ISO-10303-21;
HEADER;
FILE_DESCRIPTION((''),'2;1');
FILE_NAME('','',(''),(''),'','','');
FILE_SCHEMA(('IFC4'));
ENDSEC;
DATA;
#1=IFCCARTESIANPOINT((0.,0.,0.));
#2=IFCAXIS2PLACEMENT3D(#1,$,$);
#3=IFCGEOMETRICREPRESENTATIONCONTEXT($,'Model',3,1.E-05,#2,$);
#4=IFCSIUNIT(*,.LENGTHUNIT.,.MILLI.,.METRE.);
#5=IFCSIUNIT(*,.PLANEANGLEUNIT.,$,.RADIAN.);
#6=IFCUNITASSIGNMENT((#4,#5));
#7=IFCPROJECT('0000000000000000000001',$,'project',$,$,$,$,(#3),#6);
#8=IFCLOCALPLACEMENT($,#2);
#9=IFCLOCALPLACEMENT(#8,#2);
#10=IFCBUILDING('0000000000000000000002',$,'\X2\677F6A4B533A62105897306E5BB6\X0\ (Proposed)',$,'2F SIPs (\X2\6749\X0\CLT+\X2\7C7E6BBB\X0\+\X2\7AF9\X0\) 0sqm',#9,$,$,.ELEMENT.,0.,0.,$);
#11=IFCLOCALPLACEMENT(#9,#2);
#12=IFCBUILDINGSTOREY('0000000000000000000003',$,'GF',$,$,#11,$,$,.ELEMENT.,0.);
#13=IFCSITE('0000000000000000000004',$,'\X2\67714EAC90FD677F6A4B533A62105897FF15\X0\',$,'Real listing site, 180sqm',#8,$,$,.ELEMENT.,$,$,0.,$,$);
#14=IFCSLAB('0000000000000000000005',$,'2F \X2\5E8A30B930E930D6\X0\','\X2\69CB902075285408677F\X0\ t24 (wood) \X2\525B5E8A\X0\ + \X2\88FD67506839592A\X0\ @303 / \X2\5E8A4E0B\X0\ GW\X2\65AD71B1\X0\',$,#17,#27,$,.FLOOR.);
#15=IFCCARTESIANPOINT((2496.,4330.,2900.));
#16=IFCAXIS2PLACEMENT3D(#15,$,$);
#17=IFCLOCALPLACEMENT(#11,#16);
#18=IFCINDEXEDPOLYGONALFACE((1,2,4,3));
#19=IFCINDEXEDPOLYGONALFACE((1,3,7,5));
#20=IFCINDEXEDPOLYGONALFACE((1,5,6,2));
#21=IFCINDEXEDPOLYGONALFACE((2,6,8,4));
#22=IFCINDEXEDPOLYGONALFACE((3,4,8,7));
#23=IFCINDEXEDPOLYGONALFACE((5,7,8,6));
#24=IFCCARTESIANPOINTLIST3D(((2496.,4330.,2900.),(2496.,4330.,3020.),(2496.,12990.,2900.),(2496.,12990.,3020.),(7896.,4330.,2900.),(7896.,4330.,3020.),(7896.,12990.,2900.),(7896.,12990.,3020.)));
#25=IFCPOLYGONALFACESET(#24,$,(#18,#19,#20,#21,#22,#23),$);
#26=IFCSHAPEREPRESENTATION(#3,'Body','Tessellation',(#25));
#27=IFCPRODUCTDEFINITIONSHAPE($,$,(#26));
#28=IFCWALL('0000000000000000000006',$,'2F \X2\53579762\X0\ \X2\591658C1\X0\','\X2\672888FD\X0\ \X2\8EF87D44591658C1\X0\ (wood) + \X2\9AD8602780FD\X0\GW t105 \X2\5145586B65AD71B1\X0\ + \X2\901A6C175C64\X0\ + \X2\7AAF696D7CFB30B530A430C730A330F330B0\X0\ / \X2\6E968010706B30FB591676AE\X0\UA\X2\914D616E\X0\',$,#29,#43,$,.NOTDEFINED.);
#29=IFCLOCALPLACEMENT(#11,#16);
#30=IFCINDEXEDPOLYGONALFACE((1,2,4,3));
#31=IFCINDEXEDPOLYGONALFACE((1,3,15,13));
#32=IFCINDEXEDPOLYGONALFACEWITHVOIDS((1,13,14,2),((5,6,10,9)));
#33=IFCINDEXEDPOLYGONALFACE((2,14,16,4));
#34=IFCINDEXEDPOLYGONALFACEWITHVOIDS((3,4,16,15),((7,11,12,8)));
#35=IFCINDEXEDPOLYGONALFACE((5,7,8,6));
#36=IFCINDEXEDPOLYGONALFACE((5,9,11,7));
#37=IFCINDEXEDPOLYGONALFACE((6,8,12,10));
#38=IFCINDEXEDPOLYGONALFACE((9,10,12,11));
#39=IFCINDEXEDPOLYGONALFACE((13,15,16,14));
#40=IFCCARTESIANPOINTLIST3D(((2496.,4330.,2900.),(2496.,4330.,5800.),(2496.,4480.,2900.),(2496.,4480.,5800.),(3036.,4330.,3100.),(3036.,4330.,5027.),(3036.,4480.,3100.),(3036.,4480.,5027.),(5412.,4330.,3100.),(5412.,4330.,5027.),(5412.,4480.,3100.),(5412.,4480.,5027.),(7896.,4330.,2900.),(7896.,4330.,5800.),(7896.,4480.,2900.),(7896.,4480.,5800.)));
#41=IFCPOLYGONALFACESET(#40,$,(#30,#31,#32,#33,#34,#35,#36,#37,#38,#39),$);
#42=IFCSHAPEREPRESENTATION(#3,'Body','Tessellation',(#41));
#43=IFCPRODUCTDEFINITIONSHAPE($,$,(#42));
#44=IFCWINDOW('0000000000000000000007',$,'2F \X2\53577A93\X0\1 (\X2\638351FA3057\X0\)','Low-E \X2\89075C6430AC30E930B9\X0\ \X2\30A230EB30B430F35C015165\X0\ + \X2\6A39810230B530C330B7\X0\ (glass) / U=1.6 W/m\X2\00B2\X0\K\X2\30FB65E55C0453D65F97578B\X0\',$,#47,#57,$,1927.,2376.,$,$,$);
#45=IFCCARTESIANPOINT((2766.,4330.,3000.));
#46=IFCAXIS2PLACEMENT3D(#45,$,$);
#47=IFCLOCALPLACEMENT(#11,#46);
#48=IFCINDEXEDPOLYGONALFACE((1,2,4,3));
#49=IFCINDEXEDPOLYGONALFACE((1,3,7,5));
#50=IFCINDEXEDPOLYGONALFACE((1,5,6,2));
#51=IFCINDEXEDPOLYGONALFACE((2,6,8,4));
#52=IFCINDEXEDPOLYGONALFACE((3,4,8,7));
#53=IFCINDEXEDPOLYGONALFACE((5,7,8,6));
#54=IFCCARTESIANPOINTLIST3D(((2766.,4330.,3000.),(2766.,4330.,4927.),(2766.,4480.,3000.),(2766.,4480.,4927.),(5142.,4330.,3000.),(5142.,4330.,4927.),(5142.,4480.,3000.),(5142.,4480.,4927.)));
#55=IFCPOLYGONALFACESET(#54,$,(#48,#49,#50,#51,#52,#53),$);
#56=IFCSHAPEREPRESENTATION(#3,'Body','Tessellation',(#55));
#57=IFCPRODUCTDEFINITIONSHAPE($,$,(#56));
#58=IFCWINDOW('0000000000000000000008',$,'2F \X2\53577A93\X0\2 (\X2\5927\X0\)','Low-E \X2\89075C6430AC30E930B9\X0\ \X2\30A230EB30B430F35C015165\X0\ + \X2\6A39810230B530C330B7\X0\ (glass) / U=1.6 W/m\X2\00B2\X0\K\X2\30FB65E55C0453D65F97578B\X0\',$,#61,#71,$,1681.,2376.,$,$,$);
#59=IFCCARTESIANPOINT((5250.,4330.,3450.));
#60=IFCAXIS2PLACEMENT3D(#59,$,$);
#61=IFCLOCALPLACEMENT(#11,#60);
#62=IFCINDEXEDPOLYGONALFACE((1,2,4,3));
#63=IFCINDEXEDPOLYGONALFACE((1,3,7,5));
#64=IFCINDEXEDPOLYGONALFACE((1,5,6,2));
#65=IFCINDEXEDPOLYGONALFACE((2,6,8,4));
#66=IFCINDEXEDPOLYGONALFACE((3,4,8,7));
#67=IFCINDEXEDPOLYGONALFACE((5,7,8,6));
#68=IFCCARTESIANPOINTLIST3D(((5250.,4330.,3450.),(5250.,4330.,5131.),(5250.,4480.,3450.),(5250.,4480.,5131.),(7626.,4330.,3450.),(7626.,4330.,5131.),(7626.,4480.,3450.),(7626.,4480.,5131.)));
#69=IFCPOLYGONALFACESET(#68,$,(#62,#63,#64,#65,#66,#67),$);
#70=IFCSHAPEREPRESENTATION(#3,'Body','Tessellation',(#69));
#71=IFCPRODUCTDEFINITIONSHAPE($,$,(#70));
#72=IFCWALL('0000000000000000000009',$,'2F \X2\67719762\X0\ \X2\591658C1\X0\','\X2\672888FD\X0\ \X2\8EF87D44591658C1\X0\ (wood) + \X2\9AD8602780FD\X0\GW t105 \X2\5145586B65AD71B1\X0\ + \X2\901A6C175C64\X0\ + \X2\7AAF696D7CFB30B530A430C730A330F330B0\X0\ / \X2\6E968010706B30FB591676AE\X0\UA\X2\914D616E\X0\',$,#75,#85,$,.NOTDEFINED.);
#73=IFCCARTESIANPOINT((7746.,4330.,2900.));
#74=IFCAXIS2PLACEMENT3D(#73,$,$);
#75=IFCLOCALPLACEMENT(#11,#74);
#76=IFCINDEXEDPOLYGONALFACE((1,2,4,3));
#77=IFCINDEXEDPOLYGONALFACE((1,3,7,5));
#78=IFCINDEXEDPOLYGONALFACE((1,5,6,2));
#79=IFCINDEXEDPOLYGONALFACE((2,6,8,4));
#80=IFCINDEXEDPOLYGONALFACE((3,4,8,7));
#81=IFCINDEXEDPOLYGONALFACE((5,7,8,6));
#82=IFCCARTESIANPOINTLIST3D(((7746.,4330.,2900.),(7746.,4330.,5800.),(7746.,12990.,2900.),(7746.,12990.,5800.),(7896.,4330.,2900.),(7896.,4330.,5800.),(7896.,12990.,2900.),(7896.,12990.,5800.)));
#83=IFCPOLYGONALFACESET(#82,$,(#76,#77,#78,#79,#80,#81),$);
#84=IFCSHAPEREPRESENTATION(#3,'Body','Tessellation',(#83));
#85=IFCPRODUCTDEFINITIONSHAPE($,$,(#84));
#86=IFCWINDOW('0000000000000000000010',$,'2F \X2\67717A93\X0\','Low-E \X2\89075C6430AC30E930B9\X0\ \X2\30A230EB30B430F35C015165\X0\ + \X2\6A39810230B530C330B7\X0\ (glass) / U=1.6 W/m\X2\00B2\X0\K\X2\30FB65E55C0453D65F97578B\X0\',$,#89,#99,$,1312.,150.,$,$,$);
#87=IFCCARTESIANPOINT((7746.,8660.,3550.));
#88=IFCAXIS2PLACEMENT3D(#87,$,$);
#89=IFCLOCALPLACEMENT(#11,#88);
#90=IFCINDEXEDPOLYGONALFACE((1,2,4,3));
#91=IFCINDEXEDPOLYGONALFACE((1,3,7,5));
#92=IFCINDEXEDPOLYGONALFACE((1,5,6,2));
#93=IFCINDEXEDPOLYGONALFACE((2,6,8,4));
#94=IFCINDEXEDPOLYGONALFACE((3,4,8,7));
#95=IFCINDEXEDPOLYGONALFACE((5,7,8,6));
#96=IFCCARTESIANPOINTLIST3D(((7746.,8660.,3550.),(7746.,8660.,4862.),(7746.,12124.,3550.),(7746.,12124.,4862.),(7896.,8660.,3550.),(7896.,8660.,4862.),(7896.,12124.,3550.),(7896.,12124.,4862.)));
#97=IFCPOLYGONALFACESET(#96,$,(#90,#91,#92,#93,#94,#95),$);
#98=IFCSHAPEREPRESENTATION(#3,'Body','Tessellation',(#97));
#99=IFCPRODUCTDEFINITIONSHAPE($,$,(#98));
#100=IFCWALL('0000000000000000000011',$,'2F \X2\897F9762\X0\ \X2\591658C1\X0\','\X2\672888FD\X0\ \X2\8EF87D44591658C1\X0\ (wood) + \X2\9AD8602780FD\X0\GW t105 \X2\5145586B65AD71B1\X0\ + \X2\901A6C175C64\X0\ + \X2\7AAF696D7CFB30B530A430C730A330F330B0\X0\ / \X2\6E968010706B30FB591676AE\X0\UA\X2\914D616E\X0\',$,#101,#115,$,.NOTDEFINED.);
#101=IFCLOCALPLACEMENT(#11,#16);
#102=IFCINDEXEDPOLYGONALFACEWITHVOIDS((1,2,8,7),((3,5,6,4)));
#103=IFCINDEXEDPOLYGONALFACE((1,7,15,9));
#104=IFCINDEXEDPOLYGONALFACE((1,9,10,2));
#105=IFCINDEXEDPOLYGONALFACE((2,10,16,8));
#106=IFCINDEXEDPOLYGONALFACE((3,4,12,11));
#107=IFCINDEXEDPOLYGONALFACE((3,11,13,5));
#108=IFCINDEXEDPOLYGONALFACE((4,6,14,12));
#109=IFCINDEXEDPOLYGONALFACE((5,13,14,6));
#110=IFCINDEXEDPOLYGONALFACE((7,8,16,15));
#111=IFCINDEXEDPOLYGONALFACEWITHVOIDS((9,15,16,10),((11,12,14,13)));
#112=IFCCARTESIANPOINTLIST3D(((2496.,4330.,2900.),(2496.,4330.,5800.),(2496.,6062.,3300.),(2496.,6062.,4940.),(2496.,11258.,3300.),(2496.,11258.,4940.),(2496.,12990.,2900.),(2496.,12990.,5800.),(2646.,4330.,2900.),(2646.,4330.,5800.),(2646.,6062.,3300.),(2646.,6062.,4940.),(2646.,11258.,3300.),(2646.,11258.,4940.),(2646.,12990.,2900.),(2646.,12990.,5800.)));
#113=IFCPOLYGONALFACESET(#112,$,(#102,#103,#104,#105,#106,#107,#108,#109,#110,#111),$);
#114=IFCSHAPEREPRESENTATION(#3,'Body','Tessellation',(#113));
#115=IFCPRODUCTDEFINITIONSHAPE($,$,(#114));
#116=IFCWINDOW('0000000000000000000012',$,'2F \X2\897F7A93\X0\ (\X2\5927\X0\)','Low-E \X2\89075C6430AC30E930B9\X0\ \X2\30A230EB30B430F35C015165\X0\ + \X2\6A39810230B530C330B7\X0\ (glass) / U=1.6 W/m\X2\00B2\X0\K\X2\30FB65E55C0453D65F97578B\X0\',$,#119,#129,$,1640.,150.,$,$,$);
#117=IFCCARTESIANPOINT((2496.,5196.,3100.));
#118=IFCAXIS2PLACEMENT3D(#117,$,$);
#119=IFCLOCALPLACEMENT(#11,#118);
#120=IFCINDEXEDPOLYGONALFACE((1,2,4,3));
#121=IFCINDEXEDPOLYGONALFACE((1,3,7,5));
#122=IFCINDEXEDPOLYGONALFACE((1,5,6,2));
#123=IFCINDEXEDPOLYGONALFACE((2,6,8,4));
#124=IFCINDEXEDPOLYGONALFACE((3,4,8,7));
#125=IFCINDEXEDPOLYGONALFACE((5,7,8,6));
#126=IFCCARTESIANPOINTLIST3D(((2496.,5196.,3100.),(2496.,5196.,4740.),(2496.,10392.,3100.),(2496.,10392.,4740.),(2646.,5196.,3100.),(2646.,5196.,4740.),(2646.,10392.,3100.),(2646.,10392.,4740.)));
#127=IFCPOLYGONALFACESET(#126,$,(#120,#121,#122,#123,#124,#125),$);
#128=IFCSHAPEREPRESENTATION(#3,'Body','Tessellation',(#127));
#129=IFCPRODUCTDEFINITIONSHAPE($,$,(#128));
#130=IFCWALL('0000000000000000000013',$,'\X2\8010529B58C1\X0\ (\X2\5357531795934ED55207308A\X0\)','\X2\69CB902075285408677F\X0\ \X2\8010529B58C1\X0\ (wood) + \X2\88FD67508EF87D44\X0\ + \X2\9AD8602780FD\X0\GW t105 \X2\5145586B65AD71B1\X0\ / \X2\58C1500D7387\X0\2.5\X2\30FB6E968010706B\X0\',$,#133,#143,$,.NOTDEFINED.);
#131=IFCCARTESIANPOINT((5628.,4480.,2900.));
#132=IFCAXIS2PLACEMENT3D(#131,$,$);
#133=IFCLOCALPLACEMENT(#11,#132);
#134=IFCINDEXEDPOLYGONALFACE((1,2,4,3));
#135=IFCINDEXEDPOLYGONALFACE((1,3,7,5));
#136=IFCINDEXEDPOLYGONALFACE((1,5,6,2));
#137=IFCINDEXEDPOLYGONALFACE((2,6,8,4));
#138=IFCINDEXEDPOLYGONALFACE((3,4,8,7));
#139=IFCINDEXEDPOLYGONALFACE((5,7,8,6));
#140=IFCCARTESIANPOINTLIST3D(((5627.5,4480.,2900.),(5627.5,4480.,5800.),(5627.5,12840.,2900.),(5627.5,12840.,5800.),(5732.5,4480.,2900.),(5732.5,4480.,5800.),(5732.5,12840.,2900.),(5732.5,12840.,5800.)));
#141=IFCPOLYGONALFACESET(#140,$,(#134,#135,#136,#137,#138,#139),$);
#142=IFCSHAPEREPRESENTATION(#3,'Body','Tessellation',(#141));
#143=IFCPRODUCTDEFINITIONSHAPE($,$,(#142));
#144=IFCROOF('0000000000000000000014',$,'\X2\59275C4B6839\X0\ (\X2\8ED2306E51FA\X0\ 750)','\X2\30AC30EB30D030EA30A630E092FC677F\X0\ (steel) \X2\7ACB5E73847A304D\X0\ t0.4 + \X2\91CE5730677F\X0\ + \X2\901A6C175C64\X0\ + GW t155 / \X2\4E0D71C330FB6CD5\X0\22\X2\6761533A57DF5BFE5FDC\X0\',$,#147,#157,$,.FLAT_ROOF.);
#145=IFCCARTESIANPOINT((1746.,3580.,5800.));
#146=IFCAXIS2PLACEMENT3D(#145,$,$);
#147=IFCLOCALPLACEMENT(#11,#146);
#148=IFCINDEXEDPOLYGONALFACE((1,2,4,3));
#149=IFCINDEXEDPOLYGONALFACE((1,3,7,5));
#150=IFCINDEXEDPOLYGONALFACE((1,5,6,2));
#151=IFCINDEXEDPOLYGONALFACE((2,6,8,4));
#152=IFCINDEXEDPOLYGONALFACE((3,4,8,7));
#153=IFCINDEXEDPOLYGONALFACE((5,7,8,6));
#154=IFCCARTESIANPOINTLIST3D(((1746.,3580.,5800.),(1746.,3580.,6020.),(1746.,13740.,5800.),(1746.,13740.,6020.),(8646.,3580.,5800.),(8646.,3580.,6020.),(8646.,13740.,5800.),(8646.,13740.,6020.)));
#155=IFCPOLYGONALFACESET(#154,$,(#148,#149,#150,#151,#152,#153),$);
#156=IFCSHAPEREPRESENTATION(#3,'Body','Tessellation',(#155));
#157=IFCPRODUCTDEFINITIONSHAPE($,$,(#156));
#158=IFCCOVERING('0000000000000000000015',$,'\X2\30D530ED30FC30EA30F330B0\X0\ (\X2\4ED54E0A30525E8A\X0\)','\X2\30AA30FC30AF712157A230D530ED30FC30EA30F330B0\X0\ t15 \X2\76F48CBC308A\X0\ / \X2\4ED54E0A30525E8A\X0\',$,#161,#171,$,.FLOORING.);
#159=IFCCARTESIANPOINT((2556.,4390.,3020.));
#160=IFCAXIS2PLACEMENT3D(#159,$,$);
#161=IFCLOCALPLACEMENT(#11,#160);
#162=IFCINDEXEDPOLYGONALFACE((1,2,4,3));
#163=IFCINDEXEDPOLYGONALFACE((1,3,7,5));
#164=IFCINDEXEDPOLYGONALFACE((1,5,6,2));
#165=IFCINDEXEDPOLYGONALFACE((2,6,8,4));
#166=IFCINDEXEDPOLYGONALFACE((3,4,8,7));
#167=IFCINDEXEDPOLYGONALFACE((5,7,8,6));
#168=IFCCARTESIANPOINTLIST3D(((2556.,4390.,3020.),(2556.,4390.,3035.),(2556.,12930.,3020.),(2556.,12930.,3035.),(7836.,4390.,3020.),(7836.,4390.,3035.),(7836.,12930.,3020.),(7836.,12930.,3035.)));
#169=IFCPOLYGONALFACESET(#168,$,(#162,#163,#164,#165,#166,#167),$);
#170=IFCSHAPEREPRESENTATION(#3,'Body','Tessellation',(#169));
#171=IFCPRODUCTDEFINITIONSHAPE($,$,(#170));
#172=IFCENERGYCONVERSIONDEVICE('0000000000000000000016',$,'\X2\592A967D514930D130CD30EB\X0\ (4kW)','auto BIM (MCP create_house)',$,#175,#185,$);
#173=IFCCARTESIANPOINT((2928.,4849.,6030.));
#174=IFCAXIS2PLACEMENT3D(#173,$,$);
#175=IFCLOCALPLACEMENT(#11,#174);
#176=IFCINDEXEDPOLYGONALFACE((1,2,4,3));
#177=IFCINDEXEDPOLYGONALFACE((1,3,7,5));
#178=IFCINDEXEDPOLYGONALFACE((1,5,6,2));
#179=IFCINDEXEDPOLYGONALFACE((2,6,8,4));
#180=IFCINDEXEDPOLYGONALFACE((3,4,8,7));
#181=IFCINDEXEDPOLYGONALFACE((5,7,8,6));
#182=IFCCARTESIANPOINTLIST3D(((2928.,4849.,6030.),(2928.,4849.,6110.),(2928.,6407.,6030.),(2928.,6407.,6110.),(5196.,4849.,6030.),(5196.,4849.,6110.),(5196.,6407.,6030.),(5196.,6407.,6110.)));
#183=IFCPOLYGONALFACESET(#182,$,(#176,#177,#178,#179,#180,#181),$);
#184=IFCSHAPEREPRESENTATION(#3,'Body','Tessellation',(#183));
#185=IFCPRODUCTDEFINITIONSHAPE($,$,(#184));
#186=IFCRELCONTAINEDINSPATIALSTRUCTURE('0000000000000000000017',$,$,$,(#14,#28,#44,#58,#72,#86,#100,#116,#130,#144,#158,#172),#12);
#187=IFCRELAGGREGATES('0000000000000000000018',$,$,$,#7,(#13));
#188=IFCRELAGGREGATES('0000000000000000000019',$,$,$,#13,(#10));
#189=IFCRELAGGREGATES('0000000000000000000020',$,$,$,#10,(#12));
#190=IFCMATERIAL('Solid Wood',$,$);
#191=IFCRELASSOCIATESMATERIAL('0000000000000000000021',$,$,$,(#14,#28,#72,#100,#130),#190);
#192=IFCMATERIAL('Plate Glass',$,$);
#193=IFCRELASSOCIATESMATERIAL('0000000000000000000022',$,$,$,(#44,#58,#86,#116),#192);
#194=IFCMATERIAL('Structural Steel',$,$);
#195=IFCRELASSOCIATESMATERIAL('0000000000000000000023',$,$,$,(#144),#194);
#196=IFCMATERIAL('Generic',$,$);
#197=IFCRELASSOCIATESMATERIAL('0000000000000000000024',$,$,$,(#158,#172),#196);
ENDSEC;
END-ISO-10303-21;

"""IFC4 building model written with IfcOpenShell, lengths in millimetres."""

from ifc_helpers import new_model, si_unit, frame, frame_2d, origin, place, context, project, spatial, rectangle, extrude, material, element, fill, save


model = new_model("IFC4")

# Units and contexts
model_context = context("Model", 3, precision=1e-05, world=origin())
ifc_project = project(units=[si_unit("LENGTHUNIT", "METRE", prefix="MILLI"), si_unit("PLANEANGLEUNIT", "RADIAN")], contexts=[model_context])

# Site, building, storey
site_placement = place(None, origin())
site = spatial("IfcSite", under=ifc_project, at=site_placement, Name="東京都板橋区成増５", ObjectType="Real listing site, 180sqm", CompositionType="ELEMENT", RefElevation=0.0)
building_placement = place(site_placement, origin())
building = spatial("IfcBuilding", under=site, at=building_placement, Name="板橋区成増の家 (Proposed)", ObjectType="2F SIPs (杉CLT+籾殻+竹) 0sqm", CompositionType="ELEMENT", ElevationOfRefHeight=0.0, ElevationOfTerrain=0.0)
storey_placement = place(building_placement, origin())
storey = spatial("IfcBuildingStorey", under=building, at=storey_placement, Name="GF", CompositionType="ELEMENT", Elevation=0.0)

# Slab
ifc_material_1 = material(Name="Solid Wood")
slab_placement = place(storey_placement, frame((2496.0, 4330.0, 2900.0)))
element("IfcSlab", 1, at=slab_placement, inside=storey, material=ifc_material_1, Name="2F 床スラブ", Description="構造用合板 t24 (wood) 剛床 + 製材根太 @303 / 床下 GW断熱", PredefinedType="FLOOR", context=model_context, shape_type="SweptSolid", body=[
    extrude(rectangle(XDim=5400.0, YDim=8660.0, at=frame_2d((2700.0, 4330.0))), frame((2496.0, 4330.0, 2900.0)), (0.0, 0.0, 1.0), 120.0),
])

# Wall, openings, windows
wall_1_placement = place(storey_placement, frame((2496.0, 4330.0, 2900.0)))
wall_1 = element("IfcWall", 2, at=wall_1_placement, inside=storey, material=ifc_material_1, Name="2F 南面 外壁", Description="木製 軸組外壁 (wood) + 高性能GW t105 充填断熱 + 通気層 + 窯業系サイディング / 準耐火・外皮UA配慮", PredefinedType="NOTDEFINED", context=model_context, shape_type="SweptSolid", body=[
    extrude(rectangle(XDim=5400.0, YDim=150.0, at=frame_2d((2700.0, 75.0))), frame((2496.0, 4330.0, 2900.0)), (0.0, 0.0, 1.0), 2900.0),
])
opening_1_placement = place(storey_placement, frame((2766.0, 4330.0, 3000.0)))
opening_1 = element("IfcOpeningElement", 3, at=opening_1_placement, cuts=wall_1, PredefinedType="NOTDEFINED", context=model_context, shape_type="SweptSolid", body=[
    extrude(rectangle(XDim=2376.0, YDim=150.0, at=frame_2d((1188.0, 75.0))), frame((2766.0, 4330.0, 3000.0)), (0.0, 0.0, 1.0), 1927.0),
])
opening_2_placement = place(storey_placement, frame((5250.0, 4330.0, 3450.0)))
opening_2 = element("IfcOpeningElement", 4, at=opening_2_placement, cuts=wall_1, PredefinedType="NOTDEFINED", context=model_context, shape_type="SweptSolid", body=[
    extrude(rectangle(XDim=2376.0, YDim=150.0, at=frame_2d((1188.0, 75.0))), frame((5250.0, 4330.0, 3450.0)), (0.0, 0.0, 1.0), 1681.0),
])
ifc_material_2 = material(Name="Plate Glass")
window_1_placement = place(storey_placement, frame((2766.0, 4330.0, 3000.0)))
window_1 = element("IfcWindow", 5, at=window_1_placement, inside=storey, material=ifc_material_2, Name="2F 南窓1 (掃出し)", Description="Low-E 複層ガラス アルゴン封入 + 樹脂サッシ (glass) / U=1.6 W/m²K・日射取得型", OverallHeight=1927.0, OverallWidth=2376.0, context=model_context, shape_type="SweptSolid", body=[
    extrude(rectangle(XDim=2376.0, YDim=150.0, at=frame_2d((1188.0, 75.0))), frame((2766.0, 4330.0, 3000.0)), (0.0, 0.0, 1.0), 1927.0),
])
fill(opening_1, window_1)
window_2_placement = place(storey_placement, frame((5250.0, 4330.0, 3450.0)))
window_2 = element("IfcWindow", 6, at=window_2_placement, inside=storey, material=ifc_material_2, Name="2F 南窓2 (大)", Description="Low-E 複層ガラス アルゴン封入 + 樹脂サッシ (glass) / U=1.6 W/m²K・日射取得型", OverallHeight=1681.0, OverallWidth=2376.0, context=model_context, shape_type="SweptSolid", body=[
    extrude(rectangle(XDim=2376.0, YDim=150.0, at=frame_2d((1188.0, 75.0))), frame((5250.0, 4330.0, 3450.0)), (0.0, 0.0, 1.0), 1681.0),
])
fill(opening_2, window_2)

# Walls, openings, windows
wall_2_placement = place(storey_placement, frame((7746.0, 4330.0, 2900.0)))
wall_2 = element("IfcWall", 7, at=wall_2_placement, inside=storey, material=ifc_material_1, Name="2F 東面 外壁", Description="木製 軸組外壁 (wood) + 高性能GW t105 充填断熱 + 通気層 + 窯業系サイディング / 準耐火・外皮UA配慮", PredefinedType="NOTDEFINED", context=model_context, shape_type="SweptSolid", body=[
    extrude(rectangle(XDim=150.0, YDim=8660.0, at=frame_2d((75.0, 4330.0))), frame((7746.0, 4330.0, 2900.0)), (0.0, 0.0, 1.0), 2900.0),
])
opening_3_placement = place(storey_placement, frame((7746.0, 8660.0, 3550.0)))
opening_3 = element("IfcOpeningElement", 8, at=opening_3_placement, cuts=wall_2, PredefinedType="NOTDEFINED", context=model_context, shape_type="SweptSolid", body=[
    extrude(rectangle(XDim=150.0, YDim=3464.0, at=frame_2d((75.0, 1732.0))), frame((7746.0, 8660.0, 3550.0)), (0.0, 0.0, 1.0), 1312.0),
])
window_3_placement = place(storey_placement, frame((7746.0, 8660.0, 3550.0)))
window_3 = element("IfcWindow", 9, at=window_3_placement, inside=storey, material=ifc_material_2, Name="2F 東窓", Description="Low-E 複層ガラス アルゴン封入 + 樹脂サッシ (glass) / U=1.6 W/m²K・日射取得型", OverallHeight=1312.0, OverallWidth=150.0, context=model_context, shape_type="SweptSolid", body=[
    extrude(rectangle(XDim=150.0, YDim=3464.0, at=frame_2d((75.0, 1732.0))), frame((7746.0, 8660.0, 3550.0)), (0.0, 0.0, 1.0), 1312.0),
])
fill(opening_3, window_3)
wall_3_placement = place(storey_placement, frame((2496.0, 4330.0, 2900.0)))
wall_3 = element("IfcWall", 10, at=wall_3_placement, inside=storey, material=ifc_material_1, Name="2F 西面 外壁", Description="木製 軸組外壁 (wood) + 高性能GW t105 充填断熱 + 通気層 + 窯業系サイディング / 準耐火・外皮UA配慮", PredefinedType="NOTDEFINED", context=model_context, shape_type="SweptSolid", body=[
    extrude(rectangle(XDim=150.0, YDim=8660.0, at=frame_2d((75.0, 4330.0))), frame((2496.0, 4330.0, 2900.0)), (0.0, 0.0, 1.0), 2900.0),
])
opening_4_placement = place(storey_placement, frame((2496.0, 5196.0, 3100.0)))
opening_4 = element("IfcOpeningElement", 11, at=opening_4_placement, cuts=wall_3, PredefinedType="NOTDEFINED", context=model_context, shape_type="SweptSolid", body=[
    extrude(rectangle(XDim=150.0, YDim=5196.0, at=frame_2d((75.0, 2598.0))), frame((2496.0, 5196.0, 3100.0)), (0.0, 0.0, 1.0), 1640.0),
])
window_4_placement = place(storey_placement, frame((2496.0, 5196.0, 3100.0)))
window_4 = element("IfcWindow", 12, at=window_4_placement, inside=storey, material=ifc_material_2, Name="2F 西窓 (大)", Description="Low-E 複層ガラス アルゴン封入 + 樹脂サッシ (glass) / U=1.6 W/m²K・日射取得型", OverallHeight=1640.0, OverallWidth=150.0, context=model_context, shape_type="SweptSolid", body=[
    extrude(rectangle(XDim=150.0, YDim=5196.0, at=frame_2d((75.0, 2598.0))), frame((2496.0, 5196.0, 3100.0)), (0.0, 0.0, 1.0), 1640.0),
])
fill(opening_4, window_4)

# Wall
wall_4_placement = place(storey_placement, frame((5628.0, 4480.0, 2900.0)))
element("IfcWall", 13, at=wall_4_placement, inside=storey, material=ifc_material_1, Name="耐力壁 (南北間仕切り)", Description="構造用合板 耐力壁 (wood) + 製材軸組 + 高性能GW t105 充填断熱 / 壁倍率2.5・準耐火", PredefinedType="NOTDEFINED", context=model_context, shape_type="SweptSolid", body=[
    extrude(rectangle(XDim=105.0, YDim=8360.0, at=frame_2d((52.0, 4180.0))), frame((5628.0, 4480.0, 2900.0)), (0.0, 0.0, 1.0), 2900.0),
])

# Roof
ifc_material_3 = material(Name="Structural Steel")
roof_placement = place(storey_placement, frame((1746.0, 3580.0, 5800.0)))
element("IfcRoof", 14, at=roof_placement, inside=storey, material=ifc_material_3, Name="大屋根 (軒の出 750)", Description="ガルバリウム鋼板 (steel) 立平葺き t0.4 + 野地板 + 通気層 + GW t155 / 不燃・法22条区域対応", PredefinedType="FLAT_ROOF", context=model_context, shape_type="SweptSolid", body=[
    extrude(rectangle(XDim=6900.0, YDim=10160.0, at=frame_2d((3450.0, 5080.0))), frame((1746.0, 3580.0, 5800.0)), (0.0, 0.0, 1.0), 220.0),
])

# Covering
ifc_material_4 = material(Name="Generic")
covering_placement = place(storey_placement, frame((2556.0, 4390.0, 3020.0)))
element("IfcCovering", 15, at=covering_placement, inside=storey, material=ifc_material_4, Name="フローリング (仕上げ床)", Description="オーク無垢フローリング t15 直貼り / 仕上げ床", PredefinedType="FLOORING", context=model_context, shape_type="SweptSolid", body=[
    extrude(rectangle(XDim=5280.0, YDim=8540.0, at=frame_2d((2640.0, 4270.0))), frame((2556.0, 4390.0, 3020.0)), (0.0, 0.0, 1.0), 15.0),
])

# Energy conversion device
energy_conversion_device_placement = place(storey_placement, frame((2928.0, 4849.0, 6030.0)))
element("IfcEnergyConversionDevice", 16, at=energy_conversion_device_placement, inside=storey, material=ifc_material_4, Name="太陽光パネル (4kW)", Description="auto BIM (MCP create_house)", context=model_context, shape_type="SweptSolid", body=[
    extrude(rectangle(XDim=2268.0, YDim=1558.0, at=frame_2d((1134.0, 779.0))), frame((2928.0, 4849.0, 6030.0)), (0.0, 0.0, 1.0), 80.0),
])

save(model, "model.ifc")
